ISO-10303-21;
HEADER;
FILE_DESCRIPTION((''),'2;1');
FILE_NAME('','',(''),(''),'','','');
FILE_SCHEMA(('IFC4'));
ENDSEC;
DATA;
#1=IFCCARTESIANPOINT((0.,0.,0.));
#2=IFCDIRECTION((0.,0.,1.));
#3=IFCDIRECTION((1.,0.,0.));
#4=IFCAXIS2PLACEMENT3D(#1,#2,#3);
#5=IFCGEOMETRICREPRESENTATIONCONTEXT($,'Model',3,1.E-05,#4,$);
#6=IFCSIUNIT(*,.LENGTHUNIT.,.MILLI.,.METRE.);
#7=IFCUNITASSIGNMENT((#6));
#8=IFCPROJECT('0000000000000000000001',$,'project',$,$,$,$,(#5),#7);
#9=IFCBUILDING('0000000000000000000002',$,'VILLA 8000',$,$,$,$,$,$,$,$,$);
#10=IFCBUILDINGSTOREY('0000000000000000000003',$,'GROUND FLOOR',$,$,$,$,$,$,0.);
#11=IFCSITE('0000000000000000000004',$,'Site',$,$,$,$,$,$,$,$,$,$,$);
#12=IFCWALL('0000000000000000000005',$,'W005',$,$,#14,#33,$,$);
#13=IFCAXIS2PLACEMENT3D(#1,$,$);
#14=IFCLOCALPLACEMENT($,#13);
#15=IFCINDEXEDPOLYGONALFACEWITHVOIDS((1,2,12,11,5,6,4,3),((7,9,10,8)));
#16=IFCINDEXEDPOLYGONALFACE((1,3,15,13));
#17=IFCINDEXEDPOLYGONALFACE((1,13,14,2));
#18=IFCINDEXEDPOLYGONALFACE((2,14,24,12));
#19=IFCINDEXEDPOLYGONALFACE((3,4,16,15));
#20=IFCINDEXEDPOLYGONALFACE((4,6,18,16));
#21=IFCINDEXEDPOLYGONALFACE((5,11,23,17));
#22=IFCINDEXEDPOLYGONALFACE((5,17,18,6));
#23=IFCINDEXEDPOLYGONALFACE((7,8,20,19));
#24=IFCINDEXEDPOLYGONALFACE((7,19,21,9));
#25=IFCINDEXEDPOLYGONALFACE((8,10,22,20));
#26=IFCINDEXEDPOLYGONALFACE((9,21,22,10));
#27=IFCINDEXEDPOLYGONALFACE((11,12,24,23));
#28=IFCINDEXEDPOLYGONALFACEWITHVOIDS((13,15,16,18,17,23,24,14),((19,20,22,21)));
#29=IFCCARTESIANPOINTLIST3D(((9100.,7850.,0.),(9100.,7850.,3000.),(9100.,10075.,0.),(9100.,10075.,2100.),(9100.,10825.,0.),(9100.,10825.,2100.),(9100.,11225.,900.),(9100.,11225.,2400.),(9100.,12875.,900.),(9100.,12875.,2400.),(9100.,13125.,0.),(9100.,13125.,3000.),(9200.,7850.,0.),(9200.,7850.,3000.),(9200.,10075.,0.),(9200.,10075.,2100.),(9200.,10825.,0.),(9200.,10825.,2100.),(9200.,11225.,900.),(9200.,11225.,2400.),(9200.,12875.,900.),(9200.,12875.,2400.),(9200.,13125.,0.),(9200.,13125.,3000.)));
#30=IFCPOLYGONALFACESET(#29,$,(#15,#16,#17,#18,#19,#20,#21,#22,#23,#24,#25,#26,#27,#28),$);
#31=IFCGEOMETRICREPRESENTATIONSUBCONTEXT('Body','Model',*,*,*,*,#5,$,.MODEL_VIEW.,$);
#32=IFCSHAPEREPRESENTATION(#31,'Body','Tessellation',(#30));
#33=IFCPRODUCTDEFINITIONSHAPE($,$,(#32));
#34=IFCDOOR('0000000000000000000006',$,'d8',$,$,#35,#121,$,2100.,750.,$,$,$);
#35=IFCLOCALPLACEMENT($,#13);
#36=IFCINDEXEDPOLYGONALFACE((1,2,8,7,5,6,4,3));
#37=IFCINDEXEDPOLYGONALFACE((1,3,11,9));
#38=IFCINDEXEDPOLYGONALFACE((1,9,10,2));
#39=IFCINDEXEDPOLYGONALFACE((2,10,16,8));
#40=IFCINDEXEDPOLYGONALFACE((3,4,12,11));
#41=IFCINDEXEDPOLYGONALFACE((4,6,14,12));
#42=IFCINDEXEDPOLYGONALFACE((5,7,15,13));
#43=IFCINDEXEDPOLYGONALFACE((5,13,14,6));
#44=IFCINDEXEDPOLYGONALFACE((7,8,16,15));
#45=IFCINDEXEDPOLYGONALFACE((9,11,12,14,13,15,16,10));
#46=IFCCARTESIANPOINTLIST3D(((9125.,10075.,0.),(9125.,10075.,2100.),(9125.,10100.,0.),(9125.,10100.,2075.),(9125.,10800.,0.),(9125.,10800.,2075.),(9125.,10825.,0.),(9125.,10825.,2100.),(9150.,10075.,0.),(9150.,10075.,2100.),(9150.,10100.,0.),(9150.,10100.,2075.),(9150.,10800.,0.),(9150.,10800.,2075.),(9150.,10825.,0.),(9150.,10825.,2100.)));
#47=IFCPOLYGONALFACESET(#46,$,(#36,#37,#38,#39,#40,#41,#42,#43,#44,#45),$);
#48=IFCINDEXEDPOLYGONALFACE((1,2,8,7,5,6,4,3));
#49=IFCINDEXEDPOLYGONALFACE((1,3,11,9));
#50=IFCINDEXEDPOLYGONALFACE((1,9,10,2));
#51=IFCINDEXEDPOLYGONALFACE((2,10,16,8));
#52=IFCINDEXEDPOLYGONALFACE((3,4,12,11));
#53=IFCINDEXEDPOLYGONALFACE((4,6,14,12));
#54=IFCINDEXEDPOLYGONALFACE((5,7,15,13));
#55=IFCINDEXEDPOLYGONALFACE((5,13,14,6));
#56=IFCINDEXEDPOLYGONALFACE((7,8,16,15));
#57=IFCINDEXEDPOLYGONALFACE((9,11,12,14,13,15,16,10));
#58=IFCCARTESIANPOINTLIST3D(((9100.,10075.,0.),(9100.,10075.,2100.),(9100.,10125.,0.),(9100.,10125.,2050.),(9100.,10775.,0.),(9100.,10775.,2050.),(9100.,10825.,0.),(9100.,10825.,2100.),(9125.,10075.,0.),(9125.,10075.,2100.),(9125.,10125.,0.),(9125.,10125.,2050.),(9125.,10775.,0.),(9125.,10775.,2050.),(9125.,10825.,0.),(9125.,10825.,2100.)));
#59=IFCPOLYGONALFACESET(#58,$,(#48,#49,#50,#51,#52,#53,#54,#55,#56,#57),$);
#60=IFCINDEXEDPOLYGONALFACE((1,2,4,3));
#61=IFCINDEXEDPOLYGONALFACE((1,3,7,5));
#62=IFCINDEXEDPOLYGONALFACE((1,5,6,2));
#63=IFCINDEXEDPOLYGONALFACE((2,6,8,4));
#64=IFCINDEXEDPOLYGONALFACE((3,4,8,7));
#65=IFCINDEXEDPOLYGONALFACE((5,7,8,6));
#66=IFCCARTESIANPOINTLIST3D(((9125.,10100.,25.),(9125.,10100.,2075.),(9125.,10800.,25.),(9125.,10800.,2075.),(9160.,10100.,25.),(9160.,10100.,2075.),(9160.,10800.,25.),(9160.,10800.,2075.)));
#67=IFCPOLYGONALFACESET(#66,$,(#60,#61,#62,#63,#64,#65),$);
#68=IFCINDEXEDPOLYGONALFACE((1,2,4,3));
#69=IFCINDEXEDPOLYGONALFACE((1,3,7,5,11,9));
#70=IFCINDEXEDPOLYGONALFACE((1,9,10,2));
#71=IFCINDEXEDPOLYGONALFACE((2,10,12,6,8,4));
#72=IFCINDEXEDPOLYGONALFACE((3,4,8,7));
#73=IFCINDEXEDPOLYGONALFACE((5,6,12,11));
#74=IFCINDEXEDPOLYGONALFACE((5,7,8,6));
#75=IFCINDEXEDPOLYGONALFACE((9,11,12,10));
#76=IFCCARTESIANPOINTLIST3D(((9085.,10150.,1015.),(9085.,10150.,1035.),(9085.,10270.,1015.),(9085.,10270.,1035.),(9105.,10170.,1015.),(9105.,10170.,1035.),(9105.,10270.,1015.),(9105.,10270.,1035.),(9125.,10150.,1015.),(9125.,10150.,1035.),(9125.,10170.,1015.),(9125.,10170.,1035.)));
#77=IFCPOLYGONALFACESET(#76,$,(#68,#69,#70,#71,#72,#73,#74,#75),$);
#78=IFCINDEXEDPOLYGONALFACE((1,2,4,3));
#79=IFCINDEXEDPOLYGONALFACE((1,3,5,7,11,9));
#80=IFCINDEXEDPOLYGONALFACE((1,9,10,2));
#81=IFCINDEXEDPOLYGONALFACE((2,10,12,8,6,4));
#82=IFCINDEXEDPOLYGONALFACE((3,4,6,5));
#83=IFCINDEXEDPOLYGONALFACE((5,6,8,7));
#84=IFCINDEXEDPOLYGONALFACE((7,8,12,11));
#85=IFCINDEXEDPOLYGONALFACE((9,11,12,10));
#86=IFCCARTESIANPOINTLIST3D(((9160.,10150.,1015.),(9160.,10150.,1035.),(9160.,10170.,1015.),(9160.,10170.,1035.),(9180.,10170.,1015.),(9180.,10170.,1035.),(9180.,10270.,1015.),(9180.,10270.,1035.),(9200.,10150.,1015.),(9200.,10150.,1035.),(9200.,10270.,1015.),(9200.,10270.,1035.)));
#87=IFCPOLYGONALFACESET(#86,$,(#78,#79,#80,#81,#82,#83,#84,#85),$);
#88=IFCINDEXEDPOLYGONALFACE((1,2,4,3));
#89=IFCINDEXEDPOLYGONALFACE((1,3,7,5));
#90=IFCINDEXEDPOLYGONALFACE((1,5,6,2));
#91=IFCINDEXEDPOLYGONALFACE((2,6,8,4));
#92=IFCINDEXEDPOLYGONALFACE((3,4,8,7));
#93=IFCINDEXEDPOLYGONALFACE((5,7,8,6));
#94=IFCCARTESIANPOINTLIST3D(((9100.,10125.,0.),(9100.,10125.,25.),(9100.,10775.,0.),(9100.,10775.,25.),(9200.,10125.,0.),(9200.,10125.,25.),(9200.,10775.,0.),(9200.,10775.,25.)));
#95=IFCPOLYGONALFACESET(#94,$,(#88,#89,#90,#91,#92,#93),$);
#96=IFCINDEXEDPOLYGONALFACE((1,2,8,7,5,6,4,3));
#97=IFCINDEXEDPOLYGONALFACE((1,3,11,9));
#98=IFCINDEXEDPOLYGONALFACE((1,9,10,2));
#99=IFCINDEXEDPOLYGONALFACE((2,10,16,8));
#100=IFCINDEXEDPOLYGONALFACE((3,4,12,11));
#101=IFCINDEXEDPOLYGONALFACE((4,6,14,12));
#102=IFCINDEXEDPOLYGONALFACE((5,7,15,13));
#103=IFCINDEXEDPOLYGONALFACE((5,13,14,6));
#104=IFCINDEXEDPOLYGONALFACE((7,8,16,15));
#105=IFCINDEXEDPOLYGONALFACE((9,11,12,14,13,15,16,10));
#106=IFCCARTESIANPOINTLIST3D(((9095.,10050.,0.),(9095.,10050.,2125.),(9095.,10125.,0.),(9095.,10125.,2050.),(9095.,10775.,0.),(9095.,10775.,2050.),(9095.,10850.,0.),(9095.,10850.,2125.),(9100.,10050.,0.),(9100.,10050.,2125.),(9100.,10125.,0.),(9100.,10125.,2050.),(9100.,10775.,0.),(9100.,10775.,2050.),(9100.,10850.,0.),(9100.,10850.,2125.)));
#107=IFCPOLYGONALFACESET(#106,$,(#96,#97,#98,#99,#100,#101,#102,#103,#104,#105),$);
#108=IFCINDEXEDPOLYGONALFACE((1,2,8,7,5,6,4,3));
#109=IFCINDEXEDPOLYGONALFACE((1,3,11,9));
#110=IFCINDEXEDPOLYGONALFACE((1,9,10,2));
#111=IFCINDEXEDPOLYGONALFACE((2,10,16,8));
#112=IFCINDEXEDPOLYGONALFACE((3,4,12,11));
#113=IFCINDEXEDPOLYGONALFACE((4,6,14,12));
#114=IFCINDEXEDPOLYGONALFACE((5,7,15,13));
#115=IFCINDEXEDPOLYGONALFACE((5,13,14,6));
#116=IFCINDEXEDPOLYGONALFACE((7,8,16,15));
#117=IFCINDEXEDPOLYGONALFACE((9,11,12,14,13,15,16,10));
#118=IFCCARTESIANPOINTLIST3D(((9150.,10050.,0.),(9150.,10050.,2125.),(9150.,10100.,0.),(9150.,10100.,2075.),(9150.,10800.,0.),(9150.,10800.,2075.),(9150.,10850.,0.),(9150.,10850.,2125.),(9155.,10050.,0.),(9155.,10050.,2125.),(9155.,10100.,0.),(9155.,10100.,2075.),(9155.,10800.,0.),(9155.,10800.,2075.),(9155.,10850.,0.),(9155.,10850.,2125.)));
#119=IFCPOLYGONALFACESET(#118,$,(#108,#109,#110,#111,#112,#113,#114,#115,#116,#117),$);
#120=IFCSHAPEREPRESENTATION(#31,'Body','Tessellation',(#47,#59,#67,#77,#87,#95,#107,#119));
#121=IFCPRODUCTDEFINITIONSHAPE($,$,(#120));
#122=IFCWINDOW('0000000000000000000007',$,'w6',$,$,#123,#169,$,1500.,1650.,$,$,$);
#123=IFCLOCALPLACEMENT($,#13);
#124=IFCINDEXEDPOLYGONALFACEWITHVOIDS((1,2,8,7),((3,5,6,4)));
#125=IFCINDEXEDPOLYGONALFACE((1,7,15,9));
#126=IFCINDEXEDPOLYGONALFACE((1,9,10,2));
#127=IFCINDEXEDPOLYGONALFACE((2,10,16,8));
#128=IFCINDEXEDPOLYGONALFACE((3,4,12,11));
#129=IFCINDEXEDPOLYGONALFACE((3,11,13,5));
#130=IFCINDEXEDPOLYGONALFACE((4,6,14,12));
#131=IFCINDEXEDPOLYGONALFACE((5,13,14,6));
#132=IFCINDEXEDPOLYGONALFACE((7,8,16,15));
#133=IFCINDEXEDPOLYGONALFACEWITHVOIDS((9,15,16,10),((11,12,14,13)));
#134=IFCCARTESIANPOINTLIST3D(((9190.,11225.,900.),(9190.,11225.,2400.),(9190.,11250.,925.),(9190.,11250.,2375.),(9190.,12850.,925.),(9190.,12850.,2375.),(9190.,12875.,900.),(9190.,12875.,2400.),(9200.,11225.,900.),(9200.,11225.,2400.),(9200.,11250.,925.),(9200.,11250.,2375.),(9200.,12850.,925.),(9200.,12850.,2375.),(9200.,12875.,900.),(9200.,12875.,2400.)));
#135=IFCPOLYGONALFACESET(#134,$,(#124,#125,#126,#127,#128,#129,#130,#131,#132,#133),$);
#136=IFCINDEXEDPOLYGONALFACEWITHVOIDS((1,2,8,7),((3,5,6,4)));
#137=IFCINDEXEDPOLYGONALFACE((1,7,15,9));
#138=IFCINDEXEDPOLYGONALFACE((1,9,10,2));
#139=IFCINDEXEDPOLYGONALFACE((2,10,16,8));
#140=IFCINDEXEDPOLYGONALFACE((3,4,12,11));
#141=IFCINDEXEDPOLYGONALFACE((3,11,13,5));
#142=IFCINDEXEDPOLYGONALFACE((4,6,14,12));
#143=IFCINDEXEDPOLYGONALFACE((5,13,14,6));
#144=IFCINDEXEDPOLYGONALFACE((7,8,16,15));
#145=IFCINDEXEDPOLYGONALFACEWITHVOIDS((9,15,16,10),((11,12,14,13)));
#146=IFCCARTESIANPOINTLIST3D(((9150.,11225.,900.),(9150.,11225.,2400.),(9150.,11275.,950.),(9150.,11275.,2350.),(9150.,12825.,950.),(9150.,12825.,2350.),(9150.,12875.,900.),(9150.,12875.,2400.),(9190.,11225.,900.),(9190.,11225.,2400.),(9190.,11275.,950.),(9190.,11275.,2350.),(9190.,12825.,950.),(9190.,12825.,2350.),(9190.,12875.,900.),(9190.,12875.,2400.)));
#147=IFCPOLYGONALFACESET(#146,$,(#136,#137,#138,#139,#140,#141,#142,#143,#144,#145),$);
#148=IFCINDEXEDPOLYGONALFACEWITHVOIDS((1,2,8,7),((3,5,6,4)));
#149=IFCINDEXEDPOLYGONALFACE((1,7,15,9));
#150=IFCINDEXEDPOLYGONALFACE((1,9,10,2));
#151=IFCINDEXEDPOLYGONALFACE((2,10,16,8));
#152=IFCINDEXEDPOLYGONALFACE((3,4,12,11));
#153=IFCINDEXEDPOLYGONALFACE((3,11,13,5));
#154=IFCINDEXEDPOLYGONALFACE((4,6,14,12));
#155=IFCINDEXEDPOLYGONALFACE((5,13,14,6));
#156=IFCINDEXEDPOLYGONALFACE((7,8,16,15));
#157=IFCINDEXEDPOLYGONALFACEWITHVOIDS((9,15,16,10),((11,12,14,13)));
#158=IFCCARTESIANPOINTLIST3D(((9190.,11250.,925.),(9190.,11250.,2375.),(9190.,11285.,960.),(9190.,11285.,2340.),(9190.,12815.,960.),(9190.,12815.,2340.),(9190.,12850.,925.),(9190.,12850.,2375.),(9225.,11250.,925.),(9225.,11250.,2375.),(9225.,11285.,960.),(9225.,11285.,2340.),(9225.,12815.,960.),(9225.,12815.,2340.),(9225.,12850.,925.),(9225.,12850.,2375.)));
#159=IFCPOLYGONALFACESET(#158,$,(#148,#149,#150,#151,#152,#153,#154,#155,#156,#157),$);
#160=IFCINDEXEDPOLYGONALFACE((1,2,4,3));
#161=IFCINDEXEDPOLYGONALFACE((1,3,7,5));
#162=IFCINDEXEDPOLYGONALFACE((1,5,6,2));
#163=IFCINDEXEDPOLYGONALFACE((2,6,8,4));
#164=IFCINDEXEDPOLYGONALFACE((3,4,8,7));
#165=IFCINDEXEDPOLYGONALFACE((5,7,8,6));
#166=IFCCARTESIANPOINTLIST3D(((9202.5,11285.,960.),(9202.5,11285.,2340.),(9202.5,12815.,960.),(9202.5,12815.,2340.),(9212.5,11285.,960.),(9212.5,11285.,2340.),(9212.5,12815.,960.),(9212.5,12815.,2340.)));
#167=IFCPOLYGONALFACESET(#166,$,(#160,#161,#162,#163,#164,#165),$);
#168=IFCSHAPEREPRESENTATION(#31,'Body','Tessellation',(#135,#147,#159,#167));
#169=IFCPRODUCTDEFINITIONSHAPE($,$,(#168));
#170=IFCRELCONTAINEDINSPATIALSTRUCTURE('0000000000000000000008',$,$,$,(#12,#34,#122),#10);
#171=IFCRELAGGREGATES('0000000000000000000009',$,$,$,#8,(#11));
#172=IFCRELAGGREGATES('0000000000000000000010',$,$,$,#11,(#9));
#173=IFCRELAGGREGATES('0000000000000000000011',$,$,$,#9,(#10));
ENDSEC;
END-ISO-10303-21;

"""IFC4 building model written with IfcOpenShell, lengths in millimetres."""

from ifc_helpers import new_model, si_unit, frame, origin_with_axes, place, context, subcontext, project, spatial, line, indexed_curve, outline, extrude, element, fill, save


model = new_model("IFC4")

# Units and contexts
model_context = context("Model", 3, precision=1e-05, world=origin_with_axes())
body_context = subcontext(model_context, "Body", "Model", "MODEL_VIEW")
ifc_project = project(units=[si_unit("LENGTHUNIT", "METRE", prefix="MILLI")], contexts=[model_context])

# Site, building, storey
site = spatial("IfcSite", under=ifc_project, Name="Site")
building = spatial("IfcBuilding", under=site, Name="VILLA 8000")
storey = spatial("IfcBuildingStorey", under=building, Name="GROUND FLOOR", Elevation=0.0)

# Wall, openings, door, window
wall_1_placement = place(None, frame((9150.0, 13125.0, 0.0), z_axis=(0.0, 0.0, 1.0), x_axis=(0.0, -1.0, 0.0)))
wall_1 = element("IfcWall", 1, at=wall_1_placement, inside=storey, Name="W005", context=body_context, shape_type="SweptSolid", body=[
    extrude(outline(indexed_curve([(0.0, 0.0), (0.0, 100.0), (5275.0, 100.0), (5275.0, 0.0), (0.0, 0.0)], self_intersect=False)), frame((0.0, -50.0, 0.0), z_axis=(0.0, 0.0, 1.0), x_axis=(1.0, 0.0, 0.0)), (0.0, 0.0, 1.0), 3000.0),
])
opening_1_placement = place(wall_1_placement, frame((2300.0, 0.0, 0.0), z_axis=(0.0, 0.0, 1.0), x_axis=(1.0, 0.0, 0.0)))
opening_1 = element("IfcOpeningElement", 2, at=opening_1_placement, cuts=wall_1, context=body_context, shape_type="SweptSolid", body=[
    extrude(outline(indexed_curve([(0.0, 0.0), (0.0, 200.0), (750.0, 200.0), (750.0, 0.0), (0.0, 0.0)], self_intersect=False)), frame((0.0, -100.0, 0.0), z_axis=(0.0, 0.0, 1.0), x_axis=(1.0, 0.0, 0.0)), (0.0, 0.0, 1.0), 2100.0),
])
opening_2_placement = place(wall_1_placement, frame((250.0, 0.0, 900.0), z_axis=(0.0, 0.0, 1.0), x_axis=(1.0, 0.0, 0.0)))
opening_2 = element("IfcOpeningElement", 3, at=opening_2_placement, cuts=wall_1, context=body_context, shape_type="SweptSolid", body=[
    extrude(outline(indexed_curve([(0.0, 0.0), (0.0, 200.0), (1650.0, 200.0), (1650.0, 0.0), (0.0, 0.0)], self_intersect=False)), frame((0.0, -100.0, 0.0), z_axis=(0.0, 0.0, 1.0), x_axis=(1.0, 0.0, 0.0)), (0.0, 0.0, 1.0), 1500.0),
])
door_1_placement = place(None, frame((9100.0, 10825.0, 0.0), z_axis=(0.0, 0.0, 1.0), x_axis=(0.0, -1.0, 0.0)))
door_1 = element("IfcDoor", 4, at=door_1_placement, inside=storey, Name="d8", OverallHeight=2100.0, OverallWidth=750.0, context=body_context, shape_type="SweptSolid", body=[
    extrude(outline(indexed_curve([(0.0, 0.0), (0.0, 2100.0), (750.0, 2100.0), (750.0, 0.0), (725.0, 0.0), (725.0, 2075.0), (25.0, 2075.0), (25.0, 0.0)], segments=[line(1, 2, 3, 4, 5, 6, 7, 8, 1)])), frame((0.0, 25.0, 0.0), z_axis=(0.0, -1.0, 0.0), x_axis=(1.0, 0.0, 0.0)), (0.0, 0.0, -1.0), 25.0),
    extrude(outline(indexed_curve([(0.0, 0.0), (0.0, 2100.0), (750.0, 2100.0), (750.0, 0.0), (700.0, 0.0), (700.0, 2050.0), (50.0, 2050.0), (50.0, 0.0)], segments=[line(1, 2, 3, 4, 5, 6, 7, 8, 1)])), frame((0.0, 0.0, 0.0), z_axis=(0.0, -1.0, 0.0), x_axis=(1.0, 0.0, 0.0)), (0.0, 0.0, -1.0), 25.0),
    extrude(outline(indexed_curve([(0.0, 0.0), (700.0, 0.0), (700.0, 35.0), (0.0, 35.0)], segments=[line(1, 2, 3, 4, 1)])), frame((25.0, 25.0, 25.0), z_axis=(0.0, 0.0, 1.0), x_axis=(1.0, 0.0, 0.0)), (0.0, 0.0, 1.0), 2050.0),
    extrude(outline(indexed_curve([(0.0, 0.0), (0.0, -40.0), (-120.0, -40.0), (-120.0, -20.0), (-20.0, -20.0), (-20.0, 0.0)], segments=[line(1, 2, 3, 4, 5, 6, 1)])), frame((675.0, 25.0, 1015.0), z_axis=(0.0, 0.0, 1.0), x_axis=(1.0, 0.0, 0.0)), (0.0, 0.0, 1.0), 20.0),
    extrude(outline(indexed_curve([(0.0, 0.0), (0.0, 40.0), (-120.0, 40.0), (-120.0, 20.0), (-20.0, 20.0), (-20.0, 0.0)], segments=[line(1, 2, 3, 4, 5, 6, 1)])), frame((675.0, 60.0, 1015.0), z_axis=(0.0, 0.0, 1.0), x_axis=(1.0, 0.0, 0.0)), (0.0, 0.0, 1.0), 20.0),
    extrude(outline(indexed_curve([(0.0, 0.0), (650.0, 0.0), (650.0, 100.0), (0.0, 100.0)], segments=[line(1, 2, 3, 4, 1)])), frame((50.0, 0.0, 0.0), z_axis=(0.0, 0.0, 1.0), x_axis=(1.0, 0.0, 0.0)), (0.0, 0.0, 1.0), 25.0),
    extrude(outline(indexed_curve([(0.0, 0.0), (0.0, 2125.0), (800.0, 2125.0), (800.0, 0.0), (725.0, 0.0), (725.0, 2050.0), (75.0, 2050.0), (75.0, 0.0)], segments=[line(1, 2, 3, 4, 5, 6, 7, 8, 1)])), frame((-25.0, -5.0, 0.0), z_axis=(0.0, -1.0, 0.0), x_axis=(1.0, 0.0, 0.0)), (0.0, 0.0, -1.0), 5.0),
    extrude(outline(indexed_curve([(0.0, 0.0), (0.0, 2125.0), (800.0, 2125.0), (800.0, 0.0), (750.0, 0.0), (750.0, 2075.0), (50.0, 2075.0), (50.0, 0.0)], segments=[line(1, 2, 3, 4, 5, 6, 7, 8, 1)])), frame((-25.0, 50.0, 0.0), z_axis=(0.0, -1.0, 0.0), x_axis=(1.0, 0.0, 0.0)), (0.0, 0.0, -1.0), 5.0),
])
fill(opening_1, door_1)
window_1_placement = place(None, frame((9100.0, 12875.0, 900.0), z_axis=(0.0, 0.0, 1.0), x_axis=(0.0, -1.0, 0.0)))
window_1 = element("IfcWindow", 5, at=window_1_placement, inside=storey, Name="w6", OverallHeight=1500.0, OverallWidth=1650.0, context=body_context, shape_type="SweptSolid", body=[
    extrude(outline(indexed_curve([(0.0, 0.0), (1650.0, 0.0), (1650.0, 1500.0), (0.0, 1500.0)], segments=[line(1, 2, 3, 4, 1)]), holes=[indexed_curve([(25.0, 25.0), (1625.0, 25.0), (1625.0, 1475.0), (25.0, 1475.0)], segments=[line(1, 2, 3, 4, 1)])]), frame((0.0, 90.0, 0.0), z_axis=(0.0, -1.0, 0.0), x_axis=(1.0, 0.0, 0.0)), (0.0, 0.0, -1.0), 10.0),
    extrude(outline(indexed_curve([(0.0, 0.0), (1650.0, 0.0), (1650.0, 1500.0), (0.0, 1500.0)], segments=[line(1, 2, 3, 4, 1)]), holes=[indexed_curve([(50.0, 50.0), (1600.0, 50.0), (1600.0, 1450.0), (50.0, 1450.0)], segments=[line(1, 2, 3, 4, 1)])]), frame((0.0, 50.0, 0.0), z_axis=(0.0, -1.0, 0.0), x_axis=(1.0, 0.0, 0.0)), (0.0, 0.0, -1.0), 40.0),
    extrude(outline(indexed_curve([(0.0, 0.0), (1600.0, 0.0), (1600.0, 1450.0), (0.0, 1450.0)], segments=[line(1, 2, 3, 4, 1)]), holes=[indexed_curve([(35.0, 35.0), (1565.0, 35.0), (1565.0, 1415.0), (35.0, 1415.0)], segments=[line(1, 2, 3, 4, 1)])]), frame((25.0, 90.0, 25.0), z_axis=(0.0, -1.0, 0.0), x_axis=(1.0, 0.0, 0.0)), (0.0, 0.0, -1.0), 35.0),
    extrude(outline(indexed_curve([(35.0, 35.0), (1565.0, 35.0), (1565.0, 1415.0), (35.0, 1415.0)], segments=[line(1, 2, 3, 4, 1)])), frame((25.0, 102.5, 25.0), z_axis=(0.0, -1.0, 0.0), x_axis=(1.0, 0.0, 0.0)), (0.0, 0.0, -1.0), 10.0),
])
fill(opening_2, window_1)

save(model, "model.ifc")
